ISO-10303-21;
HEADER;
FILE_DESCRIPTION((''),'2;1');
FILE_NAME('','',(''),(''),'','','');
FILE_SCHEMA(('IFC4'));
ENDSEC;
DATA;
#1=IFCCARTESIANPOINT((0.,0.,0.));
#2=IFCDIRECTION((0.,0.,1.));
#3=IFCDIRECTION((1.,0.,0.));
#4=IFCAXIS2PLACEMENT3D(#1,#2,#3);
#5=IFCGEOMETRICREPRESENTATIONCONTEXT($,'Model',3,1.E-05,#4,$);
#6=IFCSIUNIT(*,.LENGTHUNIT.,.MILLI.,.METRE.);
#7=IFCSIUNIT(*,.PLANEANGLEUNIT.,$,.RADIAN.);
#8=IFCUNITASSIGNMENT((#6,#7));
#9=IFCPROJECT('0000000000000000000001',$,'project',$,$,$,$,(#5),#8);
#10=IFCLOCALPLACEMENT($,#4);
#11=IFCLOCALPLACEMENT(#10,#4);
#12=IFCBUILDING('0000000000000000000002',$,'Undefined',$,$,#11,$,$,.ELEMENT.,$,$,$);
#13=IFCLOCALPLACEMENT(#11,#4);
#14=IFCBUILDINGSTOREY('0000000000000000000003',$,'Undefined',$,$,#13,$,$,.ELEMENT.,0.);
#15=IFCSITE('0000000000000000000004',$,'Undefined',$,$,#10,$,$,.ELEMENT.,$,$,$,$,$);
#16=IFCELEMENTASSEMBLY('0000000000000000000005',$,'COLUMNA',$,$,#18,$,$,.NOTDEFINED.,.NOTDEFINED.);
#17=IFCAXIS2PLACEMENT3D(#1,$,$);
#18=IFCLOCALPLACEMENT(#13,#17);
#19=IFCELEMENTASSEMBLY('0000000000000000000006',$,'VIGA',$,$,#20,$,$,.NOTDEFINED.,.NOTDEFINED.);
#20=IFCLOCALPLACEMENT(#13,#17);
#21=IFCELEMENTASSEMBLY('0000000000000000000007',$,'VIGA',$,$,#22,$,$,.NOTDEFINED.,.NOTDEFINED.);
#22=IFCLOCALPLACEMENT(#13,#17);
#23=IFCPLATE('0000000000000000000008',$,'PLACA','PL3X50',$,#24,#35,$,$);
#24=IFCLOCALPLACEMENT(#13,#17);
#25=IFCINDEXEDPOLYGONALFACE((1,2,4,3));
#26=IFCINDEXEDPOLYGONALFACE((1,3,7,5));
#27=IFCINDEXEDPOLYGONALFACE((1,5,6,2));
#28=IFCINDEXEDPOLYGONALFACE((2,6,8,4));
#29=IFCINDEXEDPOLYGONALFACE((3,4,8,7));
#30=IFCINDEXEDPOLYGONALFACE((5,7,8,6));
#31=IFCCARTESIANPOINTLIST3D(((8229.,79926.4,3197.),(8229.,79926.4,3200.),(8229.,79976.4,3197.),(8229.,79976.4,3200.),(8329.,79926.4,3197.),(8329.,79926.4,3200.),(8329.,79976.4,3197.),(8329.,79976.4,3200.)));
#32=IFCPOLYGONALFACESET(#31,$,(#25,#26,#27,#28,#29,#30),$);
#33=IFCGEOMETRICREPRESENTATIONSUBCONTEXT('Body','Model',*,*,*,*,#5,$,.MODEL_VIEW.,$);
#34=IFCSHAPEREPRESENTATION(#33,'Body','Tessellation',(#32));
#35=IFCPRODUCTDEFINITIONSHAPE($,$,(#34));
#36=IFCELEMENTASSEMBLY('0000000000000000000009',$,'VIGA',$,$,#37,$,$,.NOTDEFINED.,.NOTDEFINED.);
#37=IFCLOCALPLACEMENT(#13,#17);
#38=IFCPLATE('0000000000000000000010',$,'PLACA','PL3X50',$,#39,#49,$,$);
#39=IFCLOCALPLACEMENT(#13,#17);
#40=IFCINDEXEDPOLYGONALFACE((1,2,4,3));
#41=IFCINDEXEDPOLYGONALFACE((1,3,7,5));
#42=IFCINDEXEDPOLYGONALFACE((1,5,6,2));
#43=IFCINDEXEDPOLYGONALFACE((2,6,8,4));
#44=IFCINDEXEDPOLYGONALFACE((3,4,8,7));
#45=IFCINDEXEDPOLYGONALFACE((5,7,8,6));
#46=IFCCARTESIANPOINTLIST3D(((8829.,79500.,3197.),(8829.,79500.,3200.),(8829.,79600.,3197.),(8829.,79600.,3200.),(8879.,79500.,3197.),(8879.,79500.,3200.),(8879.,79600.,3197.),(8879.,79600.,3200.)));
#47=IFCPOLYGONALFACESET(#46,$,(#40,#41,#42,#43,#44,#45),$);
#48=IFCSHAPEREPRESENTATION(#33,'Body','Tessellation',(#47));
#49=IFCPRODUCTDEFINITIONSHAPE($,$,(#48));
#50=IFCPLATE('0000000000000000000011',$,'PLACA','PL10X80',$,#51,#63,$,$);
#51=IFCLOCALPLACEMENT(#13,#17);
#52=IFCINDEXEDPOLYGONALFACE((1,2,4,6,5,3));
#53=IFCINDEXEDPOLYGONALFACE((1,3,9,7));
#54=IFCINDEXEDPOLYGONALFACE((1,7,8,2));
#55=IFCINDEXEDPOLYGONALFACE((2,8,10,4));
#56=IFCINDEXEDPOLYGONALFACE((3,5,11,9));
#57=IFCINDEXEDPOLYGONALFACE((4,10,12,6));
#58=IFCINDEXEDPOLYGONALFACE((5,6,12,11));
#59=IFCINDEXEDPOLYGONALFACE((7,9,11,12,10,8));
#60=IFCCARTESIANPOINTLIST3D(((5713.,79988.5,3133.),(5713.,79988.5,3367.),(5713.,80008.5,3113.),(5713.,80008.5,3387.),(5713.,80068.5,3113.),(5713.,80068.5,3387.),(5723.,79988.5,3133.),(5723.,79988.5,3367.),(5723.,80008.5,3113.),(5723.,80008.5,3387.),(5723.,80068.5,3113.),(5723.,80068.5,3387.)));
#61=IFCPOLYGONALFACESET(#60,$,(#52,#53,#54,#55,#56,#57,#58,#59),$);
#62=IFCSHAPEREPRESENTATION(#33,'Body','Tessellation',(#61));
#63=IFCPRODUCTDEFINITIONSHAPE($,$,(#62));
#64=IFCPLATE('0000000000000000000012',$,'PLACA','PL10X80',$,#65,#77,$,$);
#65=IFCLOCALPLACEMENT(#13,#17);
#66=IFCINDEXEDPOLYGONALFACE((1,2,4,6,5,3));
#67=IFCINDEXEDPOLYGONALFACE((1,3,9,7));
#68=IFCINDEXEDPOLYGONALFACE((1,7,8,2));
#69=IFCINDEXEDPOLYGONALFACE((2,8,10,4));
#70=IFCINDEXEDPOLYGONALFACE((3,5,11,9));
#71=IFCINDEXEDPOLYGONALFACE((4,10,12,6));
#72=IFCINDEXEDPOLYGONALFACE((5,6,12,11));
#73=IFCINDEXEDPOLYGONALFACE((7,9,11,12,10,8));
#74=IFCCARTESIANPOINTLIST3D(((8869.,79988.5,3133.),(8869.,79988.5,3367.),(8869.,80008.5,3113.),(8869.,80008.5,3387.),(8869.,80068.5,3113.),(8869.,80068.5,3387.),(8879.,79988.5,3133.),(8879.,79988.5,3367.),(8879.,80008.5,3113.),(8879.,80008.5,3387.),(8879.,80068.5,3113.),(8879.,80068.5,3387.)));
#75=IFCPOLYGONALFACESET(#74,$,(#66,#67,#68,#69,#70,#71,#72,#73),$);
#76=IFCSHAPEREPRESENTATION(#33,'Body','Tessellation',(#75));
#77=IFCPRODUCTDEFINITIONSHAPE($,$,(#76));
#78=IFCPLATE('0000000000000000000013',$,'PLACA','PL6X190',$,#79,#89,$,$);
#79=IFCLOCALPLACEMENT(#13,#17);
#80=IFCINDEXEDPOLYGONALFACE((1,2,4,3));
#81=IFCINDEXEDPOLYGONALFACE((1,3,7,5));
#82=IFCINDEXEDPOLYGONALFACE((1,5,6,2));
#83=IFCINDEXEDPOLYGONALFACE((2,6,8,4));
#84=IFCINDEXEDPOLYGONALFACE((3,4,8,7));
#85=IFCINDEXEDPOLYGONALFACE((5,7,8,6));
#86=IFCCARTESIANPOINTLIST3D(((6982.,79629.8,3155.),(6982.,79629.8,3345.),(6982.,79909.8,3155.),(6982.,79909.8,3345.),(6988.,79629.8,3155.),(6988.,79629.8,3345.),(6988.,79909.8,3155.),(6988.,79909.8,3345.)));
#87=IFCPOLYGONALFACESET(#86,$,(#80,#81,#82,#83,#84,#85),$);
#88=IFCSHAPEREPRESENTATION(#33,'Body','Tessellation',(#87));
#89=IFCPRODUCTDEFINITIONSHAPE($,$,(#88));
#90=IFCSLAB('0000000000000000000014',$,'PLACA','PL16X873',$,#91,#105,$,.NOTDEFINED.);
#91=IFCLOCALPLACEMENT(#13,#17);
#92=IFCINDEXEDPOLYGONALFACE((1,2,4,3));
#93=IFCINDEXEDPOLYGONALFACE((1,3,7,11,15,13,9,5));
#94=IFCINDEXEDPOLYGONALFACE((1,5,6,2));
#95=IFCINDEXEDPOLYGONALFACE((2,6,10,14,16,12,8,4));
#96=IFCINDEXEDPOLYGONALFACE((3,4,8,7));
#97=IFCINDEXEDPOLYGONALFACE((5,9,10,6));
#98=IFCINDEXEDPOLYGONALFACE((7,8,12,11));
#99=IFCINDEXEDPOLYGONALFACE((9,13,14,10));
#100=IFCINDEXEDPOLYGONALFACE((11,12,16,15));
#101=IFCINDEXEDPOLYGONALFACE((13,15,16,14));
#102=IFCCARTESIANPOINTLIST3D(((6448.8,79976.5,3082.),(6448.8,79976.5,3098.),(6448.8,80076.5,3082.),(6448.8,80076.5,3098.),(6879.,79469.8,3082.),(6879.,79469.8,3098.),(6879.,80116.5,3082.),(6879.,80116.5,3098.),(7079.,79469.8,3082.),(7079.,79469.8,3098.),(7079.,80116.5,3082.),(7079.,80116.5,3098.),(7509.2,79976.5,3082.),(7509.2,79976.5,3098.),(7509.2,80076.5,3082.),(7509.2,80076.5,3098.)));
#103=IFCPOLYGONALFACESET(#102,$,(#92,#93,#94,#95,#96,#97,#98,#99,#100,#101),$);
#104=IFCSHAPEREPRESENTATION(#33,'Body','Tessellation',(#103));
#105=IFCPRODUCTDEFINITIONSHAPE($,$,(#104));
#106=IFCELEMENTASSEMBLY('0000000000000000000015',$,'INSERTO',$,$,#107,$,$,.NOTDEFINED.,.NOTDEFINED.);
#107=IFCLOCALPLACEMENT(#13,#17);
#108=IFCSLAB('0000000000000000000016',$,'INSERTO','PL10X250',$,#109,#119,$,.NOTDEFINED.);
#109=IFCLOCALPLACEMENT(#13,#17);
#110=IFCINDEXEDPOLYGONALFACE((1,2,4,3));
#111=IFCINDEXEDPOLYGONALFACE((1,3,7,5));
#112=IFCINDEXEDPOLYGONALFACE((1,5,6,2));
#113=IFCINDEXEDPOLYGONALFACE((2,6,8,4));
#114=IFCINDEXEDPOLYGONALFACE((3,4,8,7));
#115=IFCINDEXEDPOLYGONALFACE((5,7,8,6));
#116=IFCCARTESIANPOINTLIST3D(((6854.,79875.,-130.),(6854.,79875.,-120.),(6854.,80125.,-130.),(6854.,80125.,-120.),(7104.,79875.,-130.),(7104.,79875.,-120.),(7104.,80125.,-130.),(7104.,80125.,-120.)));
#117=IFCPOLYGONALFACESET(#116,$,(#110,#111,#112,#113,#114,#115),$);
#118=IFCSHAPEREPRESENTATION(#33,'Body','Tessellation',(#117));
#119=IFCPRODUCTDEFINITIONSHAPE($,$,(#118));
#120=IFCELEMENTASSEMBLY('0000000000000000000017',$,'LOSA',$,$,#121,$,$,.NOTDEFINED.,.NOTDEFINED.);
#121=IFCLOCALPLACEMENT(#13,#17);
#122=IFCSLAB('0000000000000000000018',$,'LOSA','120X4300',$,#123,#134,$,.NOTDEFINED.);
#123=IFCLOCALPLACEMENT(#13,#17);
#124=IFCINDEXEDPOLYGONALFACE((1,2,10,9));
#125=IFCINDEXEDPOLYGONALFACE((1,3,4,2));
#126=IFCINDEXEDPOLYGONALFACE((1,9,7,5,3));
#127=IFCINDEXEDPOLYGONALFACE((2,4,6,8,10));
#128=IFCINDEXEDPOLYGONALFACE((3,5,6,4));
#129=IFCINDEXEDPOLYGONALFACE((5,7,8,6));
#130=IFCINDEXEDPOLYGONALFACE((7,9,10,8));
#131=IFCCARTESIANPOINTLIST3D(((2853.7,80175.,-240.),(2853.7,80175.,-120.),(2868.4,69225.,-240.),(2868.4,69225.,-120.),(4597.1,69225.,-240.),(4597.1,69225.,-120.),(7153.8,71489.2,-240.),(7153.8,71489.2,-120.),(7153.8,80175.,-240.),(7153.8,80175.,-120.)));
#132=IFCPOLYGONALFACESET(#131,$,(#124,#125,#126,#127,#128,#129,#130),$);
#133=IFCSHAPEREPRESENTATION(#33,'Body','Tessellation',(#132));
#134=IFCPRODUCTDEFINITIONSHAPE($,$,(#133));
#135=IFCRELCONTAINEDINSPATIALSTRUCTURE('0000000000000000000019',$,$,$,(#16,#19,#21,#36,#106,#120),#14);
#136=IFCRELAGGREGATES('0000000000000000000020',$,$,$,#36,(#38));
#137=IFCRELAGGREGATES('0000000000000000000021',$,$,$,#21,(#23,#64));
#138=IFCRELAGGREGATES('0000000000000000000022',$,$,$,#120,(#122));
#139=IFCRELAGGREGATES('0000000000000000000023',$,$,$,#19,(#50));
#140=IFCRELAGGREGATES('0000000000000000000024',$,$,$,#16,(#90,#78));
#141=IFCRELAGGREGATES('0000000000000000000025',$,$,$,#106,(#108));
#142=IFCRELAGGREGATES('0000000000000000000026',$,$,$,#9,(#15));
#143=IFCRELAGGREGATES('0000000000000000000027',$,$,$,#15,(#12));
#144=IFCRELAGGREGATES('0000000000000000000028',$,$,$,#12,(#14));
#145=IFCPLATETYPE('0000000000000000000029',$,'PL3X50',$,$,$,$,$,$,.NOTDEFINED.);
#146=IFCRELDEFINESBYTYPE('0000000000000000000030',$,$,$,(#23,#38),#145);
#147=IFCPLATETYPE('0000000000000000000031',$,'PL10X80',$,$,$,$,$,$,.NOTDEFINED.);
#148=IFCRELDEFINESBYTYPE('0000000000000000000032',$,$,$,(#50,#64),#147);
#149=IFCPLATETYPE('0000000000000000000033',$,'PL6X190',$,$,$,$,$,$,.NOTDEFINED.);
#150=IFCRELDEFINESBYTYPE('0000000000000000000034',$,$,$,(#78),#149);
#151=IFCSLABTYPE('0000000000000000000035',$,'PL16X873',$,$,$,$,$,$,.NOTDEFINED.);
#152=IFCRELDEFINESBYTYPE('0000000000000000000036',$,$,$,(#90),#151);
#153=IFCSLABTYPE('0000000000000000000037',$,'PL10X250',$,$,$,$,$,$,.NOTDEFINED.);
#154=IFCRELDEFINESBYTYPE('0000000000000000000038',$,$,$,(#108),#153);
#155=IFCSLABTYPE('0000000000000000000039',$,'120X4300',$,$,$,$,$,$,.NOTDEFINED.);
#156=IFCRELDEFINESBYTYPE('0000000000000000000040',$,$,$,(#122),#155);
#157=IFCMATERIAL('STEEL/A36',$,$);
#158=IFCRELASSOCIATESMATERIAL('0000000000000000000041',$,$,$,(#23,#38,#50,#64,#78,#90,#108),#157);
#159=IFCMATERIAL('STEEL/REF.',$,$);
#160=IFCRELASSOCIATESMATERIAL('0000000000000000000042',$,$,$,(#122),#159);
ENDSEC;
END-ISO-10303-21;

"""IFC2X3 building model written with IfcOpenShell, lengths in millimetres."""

from ifc_helpers import new_model, si_unit, frame, origin_with_axes, place, context, subcontext, project, spatial, polyline, outline, extrude, material, type_object, element, aggregate, save


model = new_model("IFC2X3")

# Units and contexts
model_context = context("Model", 3, precision=1e-05, world=origin_with_axes())
body_context = subcontext(model_context, "Body", "Model", "MODEL_VIEW")
ifc_project = project(units=[si_unit("LENGTHUNIT", "METRE", prefix="MILLI"), si_unit("PLANEANGLEUNIT", "RADIAN")], contexts=[model_context])

# Site, building, storey
site_placement = place(None, origin_with_axes())
site = spatial("IfcSite", under=ifc_project, at=site_placement, Name="Undefined", CompositionType="ELEMENT")
building_placement = place(site_placement, origin_with_axes())
building = spatial("IfcBuilding", under=site, at=building_placement, Name="Undefined", CompositionType="ELEMENT")
storey_placement = place(building_placement, origin_with_axes())
storey = spatial("IfcBuildingStorey", under=building, at=storey_placement, Name="Undefined", CompositionType="ELEMENT", Elevation=0.0)

# Element assembly
assembly_1_placement = place(storey_placement, origin_with_axes())
assembly_1 = element("IfcElementAssembly", 1, at=assembly_1_placement, inside=storey, Name="COLUMNA", AssemblyPlace="NOTDEFINED", PredefinedType="NOTDEFINED")
ifc_material_1 = material(Name="STEEL/A36")

# Shared definitions
ifc_material_2 = material(Name="STEEL/REF.")

# Element assembly
assembly_2_placement = place(storey_placement, origin_with_axes())
assembly_2 = element("IfcElementAssembly", 2, at=assembly_2_placement, inside=storey, Name="VIGA", AssemblyPlace="NOTDEFINED", PredefinedType="NOTDEFINED")

# Element assemblies, plates
assembly_3_placement = place(storey_placement, origin_with_axes())
assembly_3 = element("IfcElementAssembly", 3, at=assembly_3_placement, inside=storey, Name="VIGA", AssemblyPlace="NOTDEFINED", PredefinedType="NOTDEFINED")
plate_type_1 = type_object("IfcPlateType", Name="PL3X50", PredefinedType="NOTDEFINED")
plate_1_placement = place(assembly_3_placement, frame((8229.0, 79976.4, 3198.5), z_axis=(0.0, 0.0, 1.0), x_axis=(0.0, -1.0, 0.0)))
plate_1 = element("IfcPlate", 4, at=plate_1_placement, type_object=plate_type_1, material=ifc_material_1, Name="PLACA", Description="PL3X50", context=body_context, shape_type="SweptSolid", body=[
    extrude(outline(polyline([(0.0, 0.0), (50.0, 0.0), (50.0, 100.0), (0.0, 100.0), (0.0, 0.0)])), frame((0.0, 0.0, -1.5), z_axis=(0.0, 0.0, 1.0), x_axis=(1.0, 0.0, 0.0)), (0.0, 0.0, 1.0), 3.0),
])
assembly_4_placement = place(storey_placement, origin_with_axes())
assembly_4 = element("IfcElementAssembly", 5, at=assembly_4_placement, inside=storey, Name="VIGA", AssemblyPlace="NOTDEFINED", PredefinedType="NOTDEFINED")
plate_2_placement = place(assembly_4_placement, frame((8829.0, 79500.0, 3198.5), z_axis=(0.0, 0.0, 1.0), x_axis=(1.0, 0.0, 0.0)))
plate_2 = element("IfcPlate", 6, at=plate_2_placement, type_object=plate_type_1, material=ifc_material_1, Name="PLACA", Description="PL3X50", context=body_context, shape_type="SweptSolid", body=[
    extrude(outline(polyline([(0.0, 0.0), (50.0, 0.0), (50.0, 100.0), (0.0, 100.0), (0.0, 0.0)])), frame((0.0, 0.0, -1.5), z_axis=(0.0, 0.0, 1.0), x_axis=(1.0, 0.0, 0.0)), (0.0, 0.0, 1.0), 3.0),
])
aggregate(assembly_4, [plate_2])

# Plates
plate_type_2 = type_object("IfcPlateType", Name="PL10X80", PredefinedType="NOTDEFINED")
plate_3_placement = place(assembly_2_placement, frame((5718.0, 79988.5, 3113.0), z_axis=(1.0, 0.0, 0.0), x_axis=(0.0, 1.0, 0.0)))
plate_3 = element("IfcPlate", 7, at=plate_3_placement, type_object=plate_type_2, material=ifc_material_1, Name="PLACA", Description="PL10X80", context=body_context, shape_type="SweptSolid", body=[
    extrude(outline(polyline([(0.0, 20.0), (20.0, 0.0), (80.0, 0.0), (80.0, 274.0), (20.0, 274.0), (0.0, 254.0), (0.0, 20.0)])), frame((0.0, 0.0, -5.0), z_axis=(0.0, 0.0, 1.0), x_axis=(1.0, 0.0, 0.0)), (0.0, 0.0, 1.0), 10.0),
])
plate_4_placement = place(assembly_3_placement, frame((8874.0, 79988.5, 3113.0), z_axis=(1.0, 0.0, 0.0), x_axis=(0.0, 1.0, 0.0)))
plate_4 = element("IfcPlate", 8, at=plate_4_placement, type_object=plate_type_2, material=ifc_material_1, Name="PLACA", Description="PL10X80", context=body_context, shape_type="SweptSolid", body=[
    extrude(outline(polyline([(0.0, 20.0), (20.0, 0.0), (80.0, 0.0), (80.0, 274.0), (20.0, 274.0), (0.0, 254.0), (0.0, 20.0)])), frame((0.0, 0.0, -5.0), z_axis=(0.0, 0.0, 1.0), x_axis=(1.0, 0.0, 0.0)), (0.0, 0.0, 1.0), 10.0),
])
aggregate(assembly_3, [plate_1, plate_4])
plate_type_3 = type_object("IfcPlateType", Name="PL6X190", PredefinedType="NOTDEFINED")
plate_5_placement = place(assembly_1_placement, frame((6985.0, 79629.8, 3250.0), z_axis=(1.0, 0.0, 0.0), x_axis=(0.0, 1.0, 0.0)))
plate_5 = element("IfcPlate", 9, at=plate_5_placement, type_object=plate_type_3, material=ifc_material_1, Name="PLACA", Description="PL6X190", context=body_context, shape_type="SweptSolid", body=[
    extrude(outline(polyline([(0.0, -95.0), (0.0, 95.0), (280.0, 95.0), (280.0, -95.0), (0.0, -95.0)])), frame((0.0, 0.0, -3.0), z_axis=(0.0, 0.0, 1.0), x_axis=(1.0, 0.0, 0.0)), (0.0, 0.0, 1.0), 6.0),
])

# Slab
slab_type_1 = type_object("IfcSlabType", Name="PL16X873", PredefinedType="NOTDEFINED")
slab_1_placement = place(assembly_1_placement, frame((7079.0, 79469.8, 3090.0), z_axis=(0.0, 0.0, 1.0), x_axis=(0.647219, 0.762304, 0.0)))
slab_1 = element("IfcSlab", 10, at=slab_1_placement, type_object=slab_type_1, material=ifc_material_1, Name="PLACA", Description="PL16X873", PredefinedType="NOTDEFINED", context=body_context, shape_type="SweptSolid", body=[
    extrude(outline(polyline([(0.0, 0.0), (664.7, 0.0), (741.0, 64.7), (493.0, 418.6), (363.6, 571.0), (54.6, 873.1), (-21.6, 808.4), (-129.4, 152.5), (0.0, 0.0)])), frame((0.0, 0.0, -8.0), z_axis=(0.0, 0.0, 1.0), x_axis=(1.0, 0.0, 0.0)), (0.0, 0.0, 1.0), 16.0),
])

# Element assemblies, slabs
assembly_5_placement = place(storey_placement, origin_with_axes())
assembly_5 = element("IfcElementAssembly", 11, at=assembly_5_placement, inside=storey, Name="INSERTO", AssemblyPlace="NOTDEFINED", PredefinedType="NOTDEFINED")
slab_type_2 = type_object("IfcSlabType", Name="PL10X250", PredefinedType="NOTDEFINED")
slab_2_placement = place(assembly_5_placement, frame((6854.0, 79875.0, -125.0), z_axis=(0.0, 0.0, 1.0), x_axis=(1.0, 0.0, 0.0)))
slab_2 = element("IfcSlab", 12, at=slab_2_placement, type_object=slab_type_2, material=ifc_material_1, Name="INSERTO", Description="PL10X250", PredefinedType="NOTDEFINED", context=body_context, shape_type="SweptSolid", body=[
    extrude(outline(polyline([(0.0, 0.0), (250.0, 0.0), (250.0, 250.0), (0.0, 250.0), (0.0, 0.0)])), frame((0.0, 0.0, -5.0), z_axis=(0.0, 0.0, 1.0), x_axis=(1.0, 0.0, 0.0)), (0.0, 0.0, 1.0), 10.0),
])
assembly_6_placement = place(storey_placement, origin_with_axes())
assembly_6 = element("IfcElementAssembly", 13, at=assembly_6_placement, inside=storey, Name="LOSA", AssemblyPlace="NOTDEFINED", PredefinedType="NOTDEFINED")
slab_type_3 = type_object("IfcSlabType", Name="120X4300", PredefinedType="NOTDEFINED")
slab_3_placement = place(assembly_6_placement, frame((7153.8, 80175.0, -180.0), z_axis=(0.0, 0.0, 1.0), x_axis=(-1.0, 0.0, 0.0)))
slab_3 = element("IfcSlab", 14, at=slab_3_placement, type_object=slab_type_3, material=ifc_material_2, Name="LOSA", Description="120X4300", PredefinedType="NOTDEFINED", context=body_context, shape_type="SweptSolid", body=[
    extrude(outline(polyline([(0.0, 0.0), (4300.2, 0.0), (4285.4, 10950.0), (2556.8, 10950.0), (0.0, 8685.8), (0.0, 0.0)])), frame((0.0, 0.0, -60.0), z_axis=(0.0, 0.0, 1.0), x_axis=(1.0, 0.0, 0.0)), (0.0, 0.0, 1.0), 120.0),
])
aggregate(assembly_6, [slab_3])

aggregate(assembly_2, [plate_3])

aggregate(assembly_1, [slab_1, plate_5])
aggregate(assembly_5, [slab_2])

save(model, "model.ifc")
